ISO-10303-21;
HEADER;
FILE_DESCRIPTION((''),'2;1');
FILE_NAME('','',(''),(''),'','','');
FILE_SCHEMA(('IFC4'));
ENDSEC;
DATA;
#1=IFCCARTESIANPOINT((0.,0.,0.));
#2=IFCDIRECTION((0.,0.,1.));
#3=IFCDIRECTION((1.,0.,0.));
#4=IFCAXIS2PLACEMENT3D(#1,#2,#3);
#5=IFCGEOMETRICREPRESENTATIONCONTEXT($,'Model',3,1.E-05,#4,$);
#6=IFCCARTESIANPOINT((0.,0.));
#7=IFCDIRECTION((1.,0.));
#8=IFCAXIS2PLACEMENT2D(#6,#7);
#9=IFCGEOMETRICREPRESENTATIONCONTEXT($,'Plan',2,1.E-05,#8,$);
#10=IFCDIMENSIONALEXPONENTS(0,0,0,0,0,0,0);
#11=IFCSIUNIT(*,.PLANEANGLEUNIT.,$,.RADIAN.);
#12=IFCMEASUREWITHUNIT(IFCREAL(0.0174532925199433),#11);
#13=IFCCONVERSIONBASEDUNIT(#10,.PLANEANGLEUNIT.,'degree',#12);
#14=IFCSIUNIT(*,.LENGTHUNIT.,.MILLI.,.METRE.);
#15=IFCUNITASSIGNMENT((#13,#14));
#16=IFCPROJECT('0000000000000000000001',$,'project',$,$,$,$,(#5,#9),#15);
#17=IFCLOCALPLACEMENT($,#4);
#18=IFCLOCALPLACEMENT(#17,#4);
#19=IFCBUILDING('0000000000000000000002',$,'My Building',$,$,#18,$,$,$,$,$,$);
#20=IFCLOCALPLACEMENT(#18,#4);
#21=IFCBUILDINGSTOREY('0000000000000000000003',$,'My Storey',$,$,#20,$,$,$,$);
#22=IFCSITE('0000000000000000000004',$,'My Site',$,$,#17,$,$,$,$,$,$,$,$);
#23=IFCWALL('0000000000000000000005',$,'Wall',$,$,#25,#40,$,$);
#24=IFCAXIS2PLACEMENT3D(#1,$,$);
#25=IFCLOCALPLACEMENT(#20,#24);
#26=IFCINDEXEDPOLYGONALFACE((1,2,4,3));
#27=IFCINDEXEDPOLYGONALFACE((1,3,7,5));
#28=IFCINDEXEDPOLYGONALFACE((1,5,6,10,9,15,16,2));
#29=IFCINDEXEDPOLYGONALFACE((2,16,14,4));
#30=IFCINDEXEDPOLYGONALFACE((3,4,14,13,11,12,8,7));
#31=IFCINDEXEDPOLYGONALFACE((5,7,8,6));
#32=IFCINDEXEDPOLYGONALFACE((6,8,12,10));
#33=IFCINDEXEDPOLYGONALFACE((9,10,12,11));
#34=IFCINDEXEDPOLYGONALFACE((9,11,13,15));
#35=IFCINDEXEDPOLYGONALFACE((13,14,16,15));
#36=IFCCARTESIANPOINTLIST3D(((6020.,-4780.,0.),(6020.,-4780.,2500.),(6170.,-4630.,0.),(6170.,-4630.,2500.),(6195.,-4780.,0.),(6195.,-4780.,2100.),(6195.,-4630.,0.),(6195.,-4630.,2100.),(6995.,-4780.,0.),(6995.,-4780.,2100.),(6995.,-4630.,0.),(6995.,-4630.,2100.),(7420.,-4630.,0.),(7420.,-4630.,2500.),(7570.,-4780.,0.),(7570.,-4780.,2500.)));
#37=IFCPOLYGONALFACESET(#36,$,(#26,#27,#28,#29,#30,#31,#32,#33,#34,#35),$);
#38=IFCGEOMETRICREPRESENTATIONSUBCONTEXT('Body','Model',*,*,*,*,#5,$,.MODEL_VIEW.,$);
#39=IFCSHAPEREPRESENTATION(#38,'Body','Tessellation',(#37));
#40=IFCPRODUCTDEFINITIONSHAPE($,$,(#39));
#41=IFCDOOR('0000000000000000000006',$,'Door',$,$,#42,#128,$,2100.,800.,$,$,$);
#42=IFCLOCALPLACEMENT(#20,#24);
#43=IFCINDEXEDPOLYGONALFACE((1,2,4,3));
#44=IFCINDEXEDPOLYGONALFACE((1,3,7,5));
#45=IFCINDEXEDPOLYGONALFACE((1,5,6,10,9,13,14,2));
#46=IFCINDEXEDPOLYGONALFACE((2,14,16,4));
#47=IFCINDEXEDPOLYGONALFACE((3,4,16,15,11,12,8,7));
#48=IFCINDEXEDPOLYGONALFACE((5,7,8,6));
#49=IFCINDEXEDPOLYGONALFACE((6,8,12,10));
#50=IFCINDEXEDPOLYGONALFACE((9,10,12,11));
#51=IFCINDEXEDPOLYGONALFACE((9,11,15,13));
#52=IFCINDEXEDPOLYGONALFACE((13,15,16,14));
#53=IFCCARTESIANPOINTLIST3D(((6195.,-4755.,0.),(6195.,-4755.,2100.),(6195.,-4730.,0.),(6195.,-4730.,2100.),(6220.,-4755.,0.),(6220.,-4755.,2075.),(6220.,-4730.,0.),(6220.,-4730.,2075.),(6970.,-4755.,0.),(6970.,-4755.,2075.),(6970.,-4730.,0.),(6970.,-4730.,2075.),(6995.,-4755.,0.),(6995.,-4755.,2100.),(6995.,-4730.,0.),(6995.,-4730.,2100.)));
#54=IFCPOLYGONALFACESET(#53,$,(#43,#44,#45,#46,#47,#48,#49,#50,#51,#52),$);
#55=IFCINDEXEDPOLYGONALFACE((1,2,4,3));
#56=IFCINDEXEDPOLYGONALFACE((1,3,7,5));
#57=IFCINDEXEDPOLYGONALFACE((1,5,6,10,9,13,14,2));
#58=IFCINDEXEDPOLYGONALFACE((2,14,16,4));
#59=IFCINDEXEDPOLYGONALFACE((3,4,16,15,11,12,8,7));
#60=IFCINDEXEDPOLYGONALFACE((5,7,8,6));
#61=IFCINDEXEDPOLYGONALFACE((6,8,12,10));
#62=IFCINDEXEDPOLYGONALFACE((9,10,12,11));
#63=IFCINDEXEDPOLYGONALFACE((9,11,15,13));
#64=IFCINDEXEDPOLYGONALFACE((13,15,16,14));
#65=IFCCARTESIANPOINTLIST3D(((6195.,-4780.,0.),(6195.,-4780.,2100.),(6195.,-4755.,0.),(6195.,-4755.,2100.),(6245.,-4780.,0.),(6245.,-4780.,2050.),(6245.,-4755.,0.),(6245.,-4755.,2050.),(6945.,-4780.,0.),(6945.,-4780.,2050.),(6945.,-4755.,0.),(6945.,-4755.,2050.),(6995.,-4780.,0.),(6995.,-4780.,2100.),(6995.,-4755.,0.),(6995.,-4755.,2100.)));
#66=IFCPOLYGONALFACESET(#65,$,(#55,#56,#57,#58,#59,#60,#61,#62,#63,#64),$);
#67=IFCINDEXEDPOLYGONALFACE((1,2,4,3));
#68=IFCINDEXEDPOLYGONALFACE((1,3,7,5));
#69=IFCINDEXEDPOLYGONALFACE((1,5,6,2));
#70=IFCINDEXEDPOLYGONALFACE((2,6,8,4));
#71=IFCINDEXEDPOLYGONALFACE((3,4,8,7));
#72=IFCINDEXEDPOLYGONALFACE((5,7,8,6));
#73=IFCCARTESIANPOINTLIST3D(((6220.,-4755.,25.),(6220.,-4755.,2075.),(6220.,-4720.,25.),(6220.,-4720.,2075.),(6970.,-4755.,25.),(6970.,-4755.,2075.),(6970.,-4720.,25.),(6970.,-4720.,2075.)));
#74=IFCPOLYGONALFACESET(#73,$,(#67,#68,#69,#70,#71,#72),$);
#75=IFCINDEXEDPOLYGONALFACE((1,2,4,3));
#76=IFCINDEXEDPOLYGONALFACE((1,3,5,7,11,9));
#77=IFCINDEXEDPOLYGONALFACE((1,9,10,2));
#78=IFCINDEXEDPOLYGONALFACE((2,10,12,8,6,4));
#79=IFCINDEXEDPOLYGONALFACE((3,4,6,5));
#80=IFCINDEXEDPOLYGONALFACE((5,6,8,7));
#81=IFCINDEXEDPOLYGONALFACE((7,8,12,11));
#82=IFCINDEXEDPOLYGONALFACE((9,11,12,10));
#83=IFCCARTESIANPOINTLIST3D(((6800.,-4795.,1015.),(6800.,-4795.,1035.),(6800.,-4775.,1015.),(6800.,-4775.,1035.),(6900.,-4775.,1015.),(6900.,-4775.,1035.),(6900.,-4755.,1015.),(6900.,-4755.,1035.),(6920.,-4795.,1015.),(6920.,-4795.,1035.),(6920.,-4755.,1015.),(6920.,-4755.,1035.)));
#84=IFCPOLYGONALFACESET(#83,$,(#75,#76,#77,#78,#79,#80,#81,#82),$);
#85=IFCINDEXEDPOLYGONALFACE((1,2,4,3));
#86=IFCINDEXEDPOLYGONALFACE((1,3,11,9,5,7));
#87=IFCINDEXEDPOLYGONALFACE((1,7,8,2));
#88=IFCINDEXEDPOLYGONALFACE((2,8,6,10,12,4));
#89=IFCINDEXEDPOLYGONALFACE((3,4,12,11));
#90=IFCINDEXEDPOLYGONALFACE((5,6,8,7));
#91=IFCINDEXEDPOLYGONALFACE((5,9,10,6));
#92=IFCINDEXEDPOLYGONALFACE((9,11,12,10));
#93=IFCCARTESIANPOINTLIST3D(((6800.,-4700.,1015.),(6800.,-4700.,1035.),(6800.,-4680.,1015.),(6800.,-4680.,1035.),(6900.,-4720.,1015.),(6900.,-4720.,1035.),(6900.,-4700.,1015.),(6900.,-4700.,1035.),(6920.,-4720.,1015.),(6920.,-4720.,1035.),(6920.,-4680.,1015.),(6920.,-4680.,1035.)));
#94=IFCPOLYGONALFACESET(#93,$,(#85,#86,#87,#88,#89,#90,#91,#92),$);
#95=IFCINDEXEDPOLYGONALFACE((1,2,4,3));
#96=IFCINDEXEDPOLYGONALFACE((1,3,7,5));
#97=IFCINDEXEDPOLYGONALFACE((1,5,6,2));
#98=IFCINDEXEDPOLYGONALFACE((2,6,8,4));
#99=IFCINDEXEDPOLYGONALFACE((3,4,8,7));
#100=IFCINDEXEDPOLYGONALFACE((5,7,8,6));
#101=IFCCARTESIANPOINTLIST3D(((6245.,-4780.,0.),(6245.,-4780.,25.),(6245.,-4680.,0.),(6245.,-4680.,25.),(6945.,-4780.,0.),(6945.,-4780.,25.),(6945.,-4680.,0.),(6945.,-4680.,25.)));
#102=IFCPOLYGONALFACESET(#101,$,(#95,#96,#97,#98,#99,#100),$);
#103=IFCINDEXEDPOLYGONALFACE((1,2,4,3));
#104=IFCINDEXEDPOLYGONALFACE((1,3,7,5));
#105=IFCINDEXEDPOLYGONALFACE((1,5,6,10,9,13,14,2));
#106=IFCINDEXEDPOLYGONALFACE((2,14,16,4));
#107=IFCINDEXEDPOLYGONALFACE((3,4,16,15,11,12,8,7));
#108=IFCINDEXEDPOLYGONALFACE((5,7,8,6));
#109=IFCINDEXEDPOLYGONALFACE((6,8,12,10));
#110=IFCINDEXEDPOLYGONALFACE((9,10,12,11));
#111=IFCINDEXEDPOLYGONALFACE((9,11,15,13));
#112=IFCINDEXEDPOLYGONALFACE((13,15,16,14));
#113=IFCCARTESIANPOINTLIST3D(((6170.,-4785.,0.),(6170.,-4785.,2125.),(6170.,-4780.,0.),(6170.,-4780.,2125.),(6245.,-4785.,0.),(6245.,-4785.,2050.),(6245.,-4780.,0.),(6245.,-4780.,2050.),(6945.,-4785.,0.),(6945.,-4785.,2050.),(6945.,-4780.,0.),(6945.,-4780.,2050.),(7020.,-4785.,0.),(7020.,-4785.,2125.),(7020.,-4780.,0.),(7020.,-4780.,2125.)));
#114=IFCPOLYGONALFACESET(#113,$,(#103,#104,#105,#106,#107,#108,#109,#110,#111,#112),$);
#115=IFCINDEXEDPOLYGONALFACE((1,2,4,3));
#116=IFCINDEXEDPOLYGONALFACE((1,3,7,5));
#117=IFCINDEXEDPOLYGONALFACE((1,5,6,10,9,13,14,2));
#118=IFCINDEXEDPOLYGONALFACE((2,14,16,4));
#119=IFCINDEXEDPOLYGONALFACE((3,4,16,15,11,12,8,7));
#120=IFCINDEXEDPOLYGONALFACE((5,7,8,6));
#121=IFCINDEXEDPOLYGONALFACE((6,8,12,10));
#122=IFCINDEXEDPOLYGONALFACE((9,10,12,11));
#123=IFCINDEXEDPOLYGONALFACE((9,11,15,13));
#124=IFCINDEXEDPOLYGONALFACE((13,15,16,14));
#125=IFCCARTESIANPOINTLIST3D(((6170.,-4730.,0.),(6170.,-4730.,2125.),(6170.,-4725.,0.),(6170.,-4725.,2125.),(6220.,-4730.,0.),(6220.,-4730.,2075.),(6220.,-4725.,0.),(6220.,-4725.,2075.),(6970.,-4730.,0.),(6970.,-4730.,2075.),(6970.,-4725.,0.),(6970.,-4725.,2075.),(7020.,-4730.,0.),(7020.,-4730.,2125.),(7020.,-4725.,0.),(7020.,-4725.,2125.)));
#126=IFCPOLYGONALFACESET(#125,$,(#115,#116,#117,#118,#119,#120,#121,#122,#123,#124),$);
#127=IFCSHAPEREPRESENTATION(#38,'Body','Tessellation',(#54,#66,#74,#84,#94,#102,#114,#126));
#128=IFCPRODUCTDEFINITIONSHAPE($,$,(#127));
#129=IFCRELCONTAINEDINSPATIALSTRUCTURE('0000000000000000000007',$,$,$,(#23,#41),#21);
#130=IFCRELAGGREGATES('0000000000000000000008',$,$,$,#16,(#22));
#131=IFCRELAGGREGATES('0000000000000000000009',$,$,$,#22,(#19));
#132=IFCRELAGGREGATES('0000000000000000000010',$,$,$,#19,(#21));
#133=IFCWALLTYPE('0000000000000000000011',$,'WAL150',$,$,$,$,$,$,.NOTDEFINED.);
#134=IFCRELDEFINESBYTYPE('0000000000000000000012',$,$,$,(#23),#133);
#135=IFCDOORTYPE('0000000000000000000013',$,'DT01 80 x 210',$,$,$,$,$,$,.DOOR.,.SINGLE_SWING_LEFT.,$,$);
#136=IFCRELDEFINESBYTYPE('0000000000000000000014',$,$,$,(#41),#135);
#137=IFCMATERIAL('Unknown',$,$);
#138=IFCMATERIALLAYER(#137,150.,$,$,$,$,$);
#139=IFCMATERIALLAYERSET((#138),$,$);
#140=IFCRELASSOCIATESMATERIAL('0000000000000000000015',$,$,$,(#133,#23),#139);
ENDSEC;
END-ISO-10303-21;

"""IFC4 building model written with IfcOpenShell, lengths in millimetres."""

from ifc_helpers import new_model, entity, si_unit, converted_unit, frame, origin_with_axes, origin_2d_with_axis, place, context, subcontext, project, spatial, line, indexed_curve, outline, extrude, shape, source, transform, mapped, material, layer, layer_set, layer_usage, type_object, type_shapes, element, fill, save


model = new_model("IFC4")

# Units and contexts
model_context = context("Model", 3, precision=1e-05, world=origin_with_axes())
plan_context = context("Plan", 2, precision=1e-05, world=origin_2d_with_axis())
body_context_1 = subcontext(model_context, "Body", "Model", "MODEL_VIEW")
body_context_2 = subcontext(plan_context, "Body", "Plan", "PLAN_VIEW")
ifc_project = project(units=[converted_unit("PLANEANGLEUNIT", "degree", entity("IfcReal", 0.0174532925199433), si_unit("PLANEANGLEUNIT", "RADIAN"), dimensions=[0, 0, 0, 0, 0, 0, 0]), si_unit("LENGTHUNIT", "METRE", prefix="MILLI")], contexts=[model_context, plan_context])

# Site, building, storey
site_placement = place(None, origin_with_axes())
site = spatial("IfcSite", under=ifc_project, at=site_placement, Name="My Site")
building_placement = place(site_placement, origin_with_axes())
building = spatial("IfcBuilding", under=site, at=building_placement, Name="My Building")
storey_placement = place(building_placement, origin_with_axes())
storey = spatial("IfcBuildingStorey", under=building, at=storey_placement, Name="My Storey")

# Shared definitions
ifc_material = material(Name="Unknown")

# Shared definitions
ifc_layer_1 = layer(ifc_material, 150.0)
ifc_layer_set_1 = layer_set([ifc_layer_1])
wall_type_1 = type_object("IfcWallType", Name="WAL150", PredefinedType="NOTDEFINED", material=ifc_layer_set_1)

# Shared definitions
shared_shape_1 = source(origin_with_axes(), body_context_1, "Body", "SweptSolid", [
    extrude(outline(indexed_curve([(0.0, 0.0), (800.0, 0.0), (800.0, 2100.0), (0.0, 2100.0)], segments=[line(1, 2, 3, 4, 1)])), frame((0.0, -600.0, 0.0), z_axis=(0.0, -1.0, 0.0), x_axis=(1.0, 0.0, 0.0)), (0.0, 0.0, -1.0), 1200.0),
])
door_type = type_object("IfcDoorType", Name="DT01 80 x 210", OperationType="SINGLE_SWING_LEFT", PredefinedType="DOOR")
shared_shape_2 = source(origin_with_axes(), body_context_1, "Body", "SweptSolid", [
    extrude(outline(indexed_curve([(0.0, 0.0), (0.0, 2100.0), (800.0, 2100.0), (800.0, 0.0), (775.0, 0.0), (775.0, 2075.0), (25.0, 2075.0), (25.0, 0.0)], segments=[line(1, 2, 3, 4, 5, 6, 7, 8, 1)])), frame((0.0, 25.0, 0.0), z_axis=(0.0, -1.0, 0.0), x_axis=(1.0, 0.0, 0.0)), (0.0, 0.0, -1.0), 25.0),
    extrude(outline(indexed_curve([(0.0, 0.0), (0.0, 2100.0), (800.0, 2100.0), (800.0, 0.0), (750.0, 0.0), (750.0, 2050.0), (50.0, 2050.0), (50.0, 0.0)], segments=[line(1, 2, 3, 4, 5, 6, 7, 8, 1)])), frame((0.0, 0.0, 0.0), z_axis=(0.0, -1.0, 0.0), x_axis=(1.0, 0.0, 0.0)), (0.0, 0.0, -1.0), 25.0),
    extrude(outline(indexed_curve([(0.0, 0.0), (750.0, 0.0), (750.0, 35.0), (0.0, 35.0)], segments=[line(1, 2, 3, 4, 1)])), frame((25.0, 25.0, 25.0), z_axis=(0.0, 0.0, 1.0), x_axis=(1.0, 0.0, 0.0)), (0.0, 0.0, 1.0), 2050.0),
    extrude(outline(indexed_curve([(0.0, 0.0), (0.0, -40.0), (-120.0, -40.0), (-120.0, -20.0), (-20.0, -20.0), (-20.0, 0.0)], segments=[line(1, 2, 3, 4, 5, 6, 1)])), frame((725.0, 25.0, 1015.0), z_axis=(0.0, 0.0, 1.0), x_axis=(1.0, 0.0, 0.0)), (0.0, 0.0, 1.0), 20.0),
    extrude(outline(indexed_curve([(0.0, 0.0), (0.0, 40.0), (-120.0, 40.0), (-120.0, 20.0), (-20.0, 20.0), (-20.0, 0.0)], segments=[line(1, 2, 3, 4, 5, 6, 1)])), frame((725.0, 60.0, 1015.0), z_axis=(0.0, 0.0, 1.0), x_axis=(1.0, 0.0, 0.0)), (0.0, 0.0, 1.0), 20.0),
    extrude(outline(indexed_curve([(0.0, 0.0), (700.0, 0.0), (700.0, 100.0), (0.0, 100.0), (0.0, 0.0)])), frame((50.0, 0.0, 0.0), z_axis=(0.0, 0.0, 1.0), x_axis=(1.0, 0.0, 0.0)), (0.0, 0.0, 1.0), 25.0),
    extrude(outline(indexed_curve([(75.0, 0.0), (75.0, 2050.0), (775.0, 2050.0), (775.0, 0.0), (850.0, 0.0), (850.0, 2125.0), (0.0, 2125.0), (0.0, 0.0), (75.0, 0.0)])), frame((-25.0, -5.0, 0.0), z_axis=(0.0, -1.0, 0.0), x_axis=(1.0, 0.0, 0.0)), (0.0, 0.0, -1.0), 5.0),
    extrude(outline(indexed_curve([(50.0, 0.0), (50.0, 2075.0), (800.0, 2075.0), (800.0, 0.0), (850.0, 0.0), (850.0, 2125.0), (0.0, 2125.0), (0.0, 0.0), (50.0, 0.0)])), frame((-25.0, 50.0, 0.0), z_axis=(0.0, -1.0, 0.0), x_axis=(1.0, 0.0, 0.0)), (0.0, 0.0, -1.0), 5.0),
])
shared_shape_3 = source(origin_with_axes(), body_context_2, "Body", "Curve2D", [
    entity("IfcIndexedPolyCurve", entity("IfcCartesianPointList2D", [[0.0, 0.0], [0.0, 50.0], [25.0, 50.0], [25.0, 25.0], [50.0, 25.0], [50.0, 0.0]]), [entity("IfcLineIndex", [1, 2, 3, 4, 5, 6, 1])]),
    entity("IfcIndexedPolyCurve", entity("IfcCartesianPointList2D", [[800.0, 0.0], [800.0, 50.0], [775.0, 50.0], [775.0, 25.0], [750.0, 25.0], [750.0, 0.0]]), [entity("IfcLineIndex", [1, 2, 3, 4, 5, 6, 1])]),
    entity("IfcTrimmedCurve", entity("IfcEllipse", entity("IfcAxis2Placement2D", entity("IfcCartesianPoint", [60.0, 50.0]), entity("IfcDirection", [1.0, 0.0])), 715.0, 750.0), [entity("IfcCartesianPoint", [775.0, 50.0])], [entity("IfcCartesianPoint", [60.0, 800.0])], True, "CARTESIAN"),
    entity("IfcIndexedPolyCurve", entity("IfcCartesianPointList2D", [[25.0, 50.0], [60.0, 50.0], [60.0, 800.0], [25.0, 800.0]]), [entity("IfcLineIndex", [1, 2, 3, 4, 1])]),
])
type_shapes(door_type, [shared_shape_2, shared_shape_3])

# Wall, opening, door
ifc_layer_usage_1 = layer_usage(ifc_layer_set_1, "AXIS2", "POSITIVE", 0.0)
wall_1_placement = place(storey_placement, frame((6020.0, -4780.0, 0.0), z_axis=(0.0, 0.0, 1.0), x_axis=(1.0, 0.000019, 0.0)))
wall_1 = element("IfcWall", 1, at=wall_1_placement, inside=storey, type_object=wall_type_1, material=ifc_layer_usage_1, Name="Wall", context=body_context_1, shape_type="SweptSolid", body=[
    extrude(outline(indexed_curve([(0.0, 0.0), (150.0, 150.0), (1400.0, 150.0), (1550.0, 0.0)], segments=[line(1, 2, 3, 4, 1)])), origin_with_axes(), (0.0, 0.0, 1.0), 2500.0),
])
opening_1_placement = place(wall_1_placement, frame((175.0, 0.0, 0.0), z_axis=(0.0, 0.0, 1.0), x_axis=(1.0, 0.0, 0.0)))
opening_1 = element("IfcOpeningElement", 2, at=opening_1_placement, cuts=wall_1, PredefinedType="OPENING", context=body_context_1, shape_type="MappedRepresentation", body=[
    mapped(shared_shape_1, transform((0.0, 0.0, 0.0), x_axis=(1.0, 0.0, 0.0), y_axis=(0.0, 1.0, 0.0), z_axis=(0.0, 0.0, 1.0), scale=1.0)),
])
door_1_placement = place(opening_1_placement, frame((0.0, 0.0, 0.0), z_axis=(0.0, 0.0, 1.0), x_axis=(1.0, 0.0, 0.0)))
door_1 = element("IfcDoor", 3, at=door_1_placement, inside=storey, type_object=door_type, Name="Door", OverallHeight=2100.0, OverallWidth=800.0, shapes=[
    shape(body_context_1, "Body", "MappedRepresentation", [mapped(shared_shape_2, transform((0.0, 0.0, 0.0), x_axis=(1.0, 0.0, 0.0), y_axis=(0.0, 1.0, 0.0), z_axis=(0.0, 0.0, 1.0), scale=1.0))]),
    shape(body_context_2, "Body", "MappedRepresentation", [mapped(shared_shape_3, transform((0.0, 0.0, 0.0), x_axis=(1.0, 0.0, 0.0), y_axis=(0.0, 1.0, 0.0), z_axis=(0.0, 0.0, 1.0), scale=1.0))]),
])
fill(opening_1, door_1)

save(model, "model.ifc")
